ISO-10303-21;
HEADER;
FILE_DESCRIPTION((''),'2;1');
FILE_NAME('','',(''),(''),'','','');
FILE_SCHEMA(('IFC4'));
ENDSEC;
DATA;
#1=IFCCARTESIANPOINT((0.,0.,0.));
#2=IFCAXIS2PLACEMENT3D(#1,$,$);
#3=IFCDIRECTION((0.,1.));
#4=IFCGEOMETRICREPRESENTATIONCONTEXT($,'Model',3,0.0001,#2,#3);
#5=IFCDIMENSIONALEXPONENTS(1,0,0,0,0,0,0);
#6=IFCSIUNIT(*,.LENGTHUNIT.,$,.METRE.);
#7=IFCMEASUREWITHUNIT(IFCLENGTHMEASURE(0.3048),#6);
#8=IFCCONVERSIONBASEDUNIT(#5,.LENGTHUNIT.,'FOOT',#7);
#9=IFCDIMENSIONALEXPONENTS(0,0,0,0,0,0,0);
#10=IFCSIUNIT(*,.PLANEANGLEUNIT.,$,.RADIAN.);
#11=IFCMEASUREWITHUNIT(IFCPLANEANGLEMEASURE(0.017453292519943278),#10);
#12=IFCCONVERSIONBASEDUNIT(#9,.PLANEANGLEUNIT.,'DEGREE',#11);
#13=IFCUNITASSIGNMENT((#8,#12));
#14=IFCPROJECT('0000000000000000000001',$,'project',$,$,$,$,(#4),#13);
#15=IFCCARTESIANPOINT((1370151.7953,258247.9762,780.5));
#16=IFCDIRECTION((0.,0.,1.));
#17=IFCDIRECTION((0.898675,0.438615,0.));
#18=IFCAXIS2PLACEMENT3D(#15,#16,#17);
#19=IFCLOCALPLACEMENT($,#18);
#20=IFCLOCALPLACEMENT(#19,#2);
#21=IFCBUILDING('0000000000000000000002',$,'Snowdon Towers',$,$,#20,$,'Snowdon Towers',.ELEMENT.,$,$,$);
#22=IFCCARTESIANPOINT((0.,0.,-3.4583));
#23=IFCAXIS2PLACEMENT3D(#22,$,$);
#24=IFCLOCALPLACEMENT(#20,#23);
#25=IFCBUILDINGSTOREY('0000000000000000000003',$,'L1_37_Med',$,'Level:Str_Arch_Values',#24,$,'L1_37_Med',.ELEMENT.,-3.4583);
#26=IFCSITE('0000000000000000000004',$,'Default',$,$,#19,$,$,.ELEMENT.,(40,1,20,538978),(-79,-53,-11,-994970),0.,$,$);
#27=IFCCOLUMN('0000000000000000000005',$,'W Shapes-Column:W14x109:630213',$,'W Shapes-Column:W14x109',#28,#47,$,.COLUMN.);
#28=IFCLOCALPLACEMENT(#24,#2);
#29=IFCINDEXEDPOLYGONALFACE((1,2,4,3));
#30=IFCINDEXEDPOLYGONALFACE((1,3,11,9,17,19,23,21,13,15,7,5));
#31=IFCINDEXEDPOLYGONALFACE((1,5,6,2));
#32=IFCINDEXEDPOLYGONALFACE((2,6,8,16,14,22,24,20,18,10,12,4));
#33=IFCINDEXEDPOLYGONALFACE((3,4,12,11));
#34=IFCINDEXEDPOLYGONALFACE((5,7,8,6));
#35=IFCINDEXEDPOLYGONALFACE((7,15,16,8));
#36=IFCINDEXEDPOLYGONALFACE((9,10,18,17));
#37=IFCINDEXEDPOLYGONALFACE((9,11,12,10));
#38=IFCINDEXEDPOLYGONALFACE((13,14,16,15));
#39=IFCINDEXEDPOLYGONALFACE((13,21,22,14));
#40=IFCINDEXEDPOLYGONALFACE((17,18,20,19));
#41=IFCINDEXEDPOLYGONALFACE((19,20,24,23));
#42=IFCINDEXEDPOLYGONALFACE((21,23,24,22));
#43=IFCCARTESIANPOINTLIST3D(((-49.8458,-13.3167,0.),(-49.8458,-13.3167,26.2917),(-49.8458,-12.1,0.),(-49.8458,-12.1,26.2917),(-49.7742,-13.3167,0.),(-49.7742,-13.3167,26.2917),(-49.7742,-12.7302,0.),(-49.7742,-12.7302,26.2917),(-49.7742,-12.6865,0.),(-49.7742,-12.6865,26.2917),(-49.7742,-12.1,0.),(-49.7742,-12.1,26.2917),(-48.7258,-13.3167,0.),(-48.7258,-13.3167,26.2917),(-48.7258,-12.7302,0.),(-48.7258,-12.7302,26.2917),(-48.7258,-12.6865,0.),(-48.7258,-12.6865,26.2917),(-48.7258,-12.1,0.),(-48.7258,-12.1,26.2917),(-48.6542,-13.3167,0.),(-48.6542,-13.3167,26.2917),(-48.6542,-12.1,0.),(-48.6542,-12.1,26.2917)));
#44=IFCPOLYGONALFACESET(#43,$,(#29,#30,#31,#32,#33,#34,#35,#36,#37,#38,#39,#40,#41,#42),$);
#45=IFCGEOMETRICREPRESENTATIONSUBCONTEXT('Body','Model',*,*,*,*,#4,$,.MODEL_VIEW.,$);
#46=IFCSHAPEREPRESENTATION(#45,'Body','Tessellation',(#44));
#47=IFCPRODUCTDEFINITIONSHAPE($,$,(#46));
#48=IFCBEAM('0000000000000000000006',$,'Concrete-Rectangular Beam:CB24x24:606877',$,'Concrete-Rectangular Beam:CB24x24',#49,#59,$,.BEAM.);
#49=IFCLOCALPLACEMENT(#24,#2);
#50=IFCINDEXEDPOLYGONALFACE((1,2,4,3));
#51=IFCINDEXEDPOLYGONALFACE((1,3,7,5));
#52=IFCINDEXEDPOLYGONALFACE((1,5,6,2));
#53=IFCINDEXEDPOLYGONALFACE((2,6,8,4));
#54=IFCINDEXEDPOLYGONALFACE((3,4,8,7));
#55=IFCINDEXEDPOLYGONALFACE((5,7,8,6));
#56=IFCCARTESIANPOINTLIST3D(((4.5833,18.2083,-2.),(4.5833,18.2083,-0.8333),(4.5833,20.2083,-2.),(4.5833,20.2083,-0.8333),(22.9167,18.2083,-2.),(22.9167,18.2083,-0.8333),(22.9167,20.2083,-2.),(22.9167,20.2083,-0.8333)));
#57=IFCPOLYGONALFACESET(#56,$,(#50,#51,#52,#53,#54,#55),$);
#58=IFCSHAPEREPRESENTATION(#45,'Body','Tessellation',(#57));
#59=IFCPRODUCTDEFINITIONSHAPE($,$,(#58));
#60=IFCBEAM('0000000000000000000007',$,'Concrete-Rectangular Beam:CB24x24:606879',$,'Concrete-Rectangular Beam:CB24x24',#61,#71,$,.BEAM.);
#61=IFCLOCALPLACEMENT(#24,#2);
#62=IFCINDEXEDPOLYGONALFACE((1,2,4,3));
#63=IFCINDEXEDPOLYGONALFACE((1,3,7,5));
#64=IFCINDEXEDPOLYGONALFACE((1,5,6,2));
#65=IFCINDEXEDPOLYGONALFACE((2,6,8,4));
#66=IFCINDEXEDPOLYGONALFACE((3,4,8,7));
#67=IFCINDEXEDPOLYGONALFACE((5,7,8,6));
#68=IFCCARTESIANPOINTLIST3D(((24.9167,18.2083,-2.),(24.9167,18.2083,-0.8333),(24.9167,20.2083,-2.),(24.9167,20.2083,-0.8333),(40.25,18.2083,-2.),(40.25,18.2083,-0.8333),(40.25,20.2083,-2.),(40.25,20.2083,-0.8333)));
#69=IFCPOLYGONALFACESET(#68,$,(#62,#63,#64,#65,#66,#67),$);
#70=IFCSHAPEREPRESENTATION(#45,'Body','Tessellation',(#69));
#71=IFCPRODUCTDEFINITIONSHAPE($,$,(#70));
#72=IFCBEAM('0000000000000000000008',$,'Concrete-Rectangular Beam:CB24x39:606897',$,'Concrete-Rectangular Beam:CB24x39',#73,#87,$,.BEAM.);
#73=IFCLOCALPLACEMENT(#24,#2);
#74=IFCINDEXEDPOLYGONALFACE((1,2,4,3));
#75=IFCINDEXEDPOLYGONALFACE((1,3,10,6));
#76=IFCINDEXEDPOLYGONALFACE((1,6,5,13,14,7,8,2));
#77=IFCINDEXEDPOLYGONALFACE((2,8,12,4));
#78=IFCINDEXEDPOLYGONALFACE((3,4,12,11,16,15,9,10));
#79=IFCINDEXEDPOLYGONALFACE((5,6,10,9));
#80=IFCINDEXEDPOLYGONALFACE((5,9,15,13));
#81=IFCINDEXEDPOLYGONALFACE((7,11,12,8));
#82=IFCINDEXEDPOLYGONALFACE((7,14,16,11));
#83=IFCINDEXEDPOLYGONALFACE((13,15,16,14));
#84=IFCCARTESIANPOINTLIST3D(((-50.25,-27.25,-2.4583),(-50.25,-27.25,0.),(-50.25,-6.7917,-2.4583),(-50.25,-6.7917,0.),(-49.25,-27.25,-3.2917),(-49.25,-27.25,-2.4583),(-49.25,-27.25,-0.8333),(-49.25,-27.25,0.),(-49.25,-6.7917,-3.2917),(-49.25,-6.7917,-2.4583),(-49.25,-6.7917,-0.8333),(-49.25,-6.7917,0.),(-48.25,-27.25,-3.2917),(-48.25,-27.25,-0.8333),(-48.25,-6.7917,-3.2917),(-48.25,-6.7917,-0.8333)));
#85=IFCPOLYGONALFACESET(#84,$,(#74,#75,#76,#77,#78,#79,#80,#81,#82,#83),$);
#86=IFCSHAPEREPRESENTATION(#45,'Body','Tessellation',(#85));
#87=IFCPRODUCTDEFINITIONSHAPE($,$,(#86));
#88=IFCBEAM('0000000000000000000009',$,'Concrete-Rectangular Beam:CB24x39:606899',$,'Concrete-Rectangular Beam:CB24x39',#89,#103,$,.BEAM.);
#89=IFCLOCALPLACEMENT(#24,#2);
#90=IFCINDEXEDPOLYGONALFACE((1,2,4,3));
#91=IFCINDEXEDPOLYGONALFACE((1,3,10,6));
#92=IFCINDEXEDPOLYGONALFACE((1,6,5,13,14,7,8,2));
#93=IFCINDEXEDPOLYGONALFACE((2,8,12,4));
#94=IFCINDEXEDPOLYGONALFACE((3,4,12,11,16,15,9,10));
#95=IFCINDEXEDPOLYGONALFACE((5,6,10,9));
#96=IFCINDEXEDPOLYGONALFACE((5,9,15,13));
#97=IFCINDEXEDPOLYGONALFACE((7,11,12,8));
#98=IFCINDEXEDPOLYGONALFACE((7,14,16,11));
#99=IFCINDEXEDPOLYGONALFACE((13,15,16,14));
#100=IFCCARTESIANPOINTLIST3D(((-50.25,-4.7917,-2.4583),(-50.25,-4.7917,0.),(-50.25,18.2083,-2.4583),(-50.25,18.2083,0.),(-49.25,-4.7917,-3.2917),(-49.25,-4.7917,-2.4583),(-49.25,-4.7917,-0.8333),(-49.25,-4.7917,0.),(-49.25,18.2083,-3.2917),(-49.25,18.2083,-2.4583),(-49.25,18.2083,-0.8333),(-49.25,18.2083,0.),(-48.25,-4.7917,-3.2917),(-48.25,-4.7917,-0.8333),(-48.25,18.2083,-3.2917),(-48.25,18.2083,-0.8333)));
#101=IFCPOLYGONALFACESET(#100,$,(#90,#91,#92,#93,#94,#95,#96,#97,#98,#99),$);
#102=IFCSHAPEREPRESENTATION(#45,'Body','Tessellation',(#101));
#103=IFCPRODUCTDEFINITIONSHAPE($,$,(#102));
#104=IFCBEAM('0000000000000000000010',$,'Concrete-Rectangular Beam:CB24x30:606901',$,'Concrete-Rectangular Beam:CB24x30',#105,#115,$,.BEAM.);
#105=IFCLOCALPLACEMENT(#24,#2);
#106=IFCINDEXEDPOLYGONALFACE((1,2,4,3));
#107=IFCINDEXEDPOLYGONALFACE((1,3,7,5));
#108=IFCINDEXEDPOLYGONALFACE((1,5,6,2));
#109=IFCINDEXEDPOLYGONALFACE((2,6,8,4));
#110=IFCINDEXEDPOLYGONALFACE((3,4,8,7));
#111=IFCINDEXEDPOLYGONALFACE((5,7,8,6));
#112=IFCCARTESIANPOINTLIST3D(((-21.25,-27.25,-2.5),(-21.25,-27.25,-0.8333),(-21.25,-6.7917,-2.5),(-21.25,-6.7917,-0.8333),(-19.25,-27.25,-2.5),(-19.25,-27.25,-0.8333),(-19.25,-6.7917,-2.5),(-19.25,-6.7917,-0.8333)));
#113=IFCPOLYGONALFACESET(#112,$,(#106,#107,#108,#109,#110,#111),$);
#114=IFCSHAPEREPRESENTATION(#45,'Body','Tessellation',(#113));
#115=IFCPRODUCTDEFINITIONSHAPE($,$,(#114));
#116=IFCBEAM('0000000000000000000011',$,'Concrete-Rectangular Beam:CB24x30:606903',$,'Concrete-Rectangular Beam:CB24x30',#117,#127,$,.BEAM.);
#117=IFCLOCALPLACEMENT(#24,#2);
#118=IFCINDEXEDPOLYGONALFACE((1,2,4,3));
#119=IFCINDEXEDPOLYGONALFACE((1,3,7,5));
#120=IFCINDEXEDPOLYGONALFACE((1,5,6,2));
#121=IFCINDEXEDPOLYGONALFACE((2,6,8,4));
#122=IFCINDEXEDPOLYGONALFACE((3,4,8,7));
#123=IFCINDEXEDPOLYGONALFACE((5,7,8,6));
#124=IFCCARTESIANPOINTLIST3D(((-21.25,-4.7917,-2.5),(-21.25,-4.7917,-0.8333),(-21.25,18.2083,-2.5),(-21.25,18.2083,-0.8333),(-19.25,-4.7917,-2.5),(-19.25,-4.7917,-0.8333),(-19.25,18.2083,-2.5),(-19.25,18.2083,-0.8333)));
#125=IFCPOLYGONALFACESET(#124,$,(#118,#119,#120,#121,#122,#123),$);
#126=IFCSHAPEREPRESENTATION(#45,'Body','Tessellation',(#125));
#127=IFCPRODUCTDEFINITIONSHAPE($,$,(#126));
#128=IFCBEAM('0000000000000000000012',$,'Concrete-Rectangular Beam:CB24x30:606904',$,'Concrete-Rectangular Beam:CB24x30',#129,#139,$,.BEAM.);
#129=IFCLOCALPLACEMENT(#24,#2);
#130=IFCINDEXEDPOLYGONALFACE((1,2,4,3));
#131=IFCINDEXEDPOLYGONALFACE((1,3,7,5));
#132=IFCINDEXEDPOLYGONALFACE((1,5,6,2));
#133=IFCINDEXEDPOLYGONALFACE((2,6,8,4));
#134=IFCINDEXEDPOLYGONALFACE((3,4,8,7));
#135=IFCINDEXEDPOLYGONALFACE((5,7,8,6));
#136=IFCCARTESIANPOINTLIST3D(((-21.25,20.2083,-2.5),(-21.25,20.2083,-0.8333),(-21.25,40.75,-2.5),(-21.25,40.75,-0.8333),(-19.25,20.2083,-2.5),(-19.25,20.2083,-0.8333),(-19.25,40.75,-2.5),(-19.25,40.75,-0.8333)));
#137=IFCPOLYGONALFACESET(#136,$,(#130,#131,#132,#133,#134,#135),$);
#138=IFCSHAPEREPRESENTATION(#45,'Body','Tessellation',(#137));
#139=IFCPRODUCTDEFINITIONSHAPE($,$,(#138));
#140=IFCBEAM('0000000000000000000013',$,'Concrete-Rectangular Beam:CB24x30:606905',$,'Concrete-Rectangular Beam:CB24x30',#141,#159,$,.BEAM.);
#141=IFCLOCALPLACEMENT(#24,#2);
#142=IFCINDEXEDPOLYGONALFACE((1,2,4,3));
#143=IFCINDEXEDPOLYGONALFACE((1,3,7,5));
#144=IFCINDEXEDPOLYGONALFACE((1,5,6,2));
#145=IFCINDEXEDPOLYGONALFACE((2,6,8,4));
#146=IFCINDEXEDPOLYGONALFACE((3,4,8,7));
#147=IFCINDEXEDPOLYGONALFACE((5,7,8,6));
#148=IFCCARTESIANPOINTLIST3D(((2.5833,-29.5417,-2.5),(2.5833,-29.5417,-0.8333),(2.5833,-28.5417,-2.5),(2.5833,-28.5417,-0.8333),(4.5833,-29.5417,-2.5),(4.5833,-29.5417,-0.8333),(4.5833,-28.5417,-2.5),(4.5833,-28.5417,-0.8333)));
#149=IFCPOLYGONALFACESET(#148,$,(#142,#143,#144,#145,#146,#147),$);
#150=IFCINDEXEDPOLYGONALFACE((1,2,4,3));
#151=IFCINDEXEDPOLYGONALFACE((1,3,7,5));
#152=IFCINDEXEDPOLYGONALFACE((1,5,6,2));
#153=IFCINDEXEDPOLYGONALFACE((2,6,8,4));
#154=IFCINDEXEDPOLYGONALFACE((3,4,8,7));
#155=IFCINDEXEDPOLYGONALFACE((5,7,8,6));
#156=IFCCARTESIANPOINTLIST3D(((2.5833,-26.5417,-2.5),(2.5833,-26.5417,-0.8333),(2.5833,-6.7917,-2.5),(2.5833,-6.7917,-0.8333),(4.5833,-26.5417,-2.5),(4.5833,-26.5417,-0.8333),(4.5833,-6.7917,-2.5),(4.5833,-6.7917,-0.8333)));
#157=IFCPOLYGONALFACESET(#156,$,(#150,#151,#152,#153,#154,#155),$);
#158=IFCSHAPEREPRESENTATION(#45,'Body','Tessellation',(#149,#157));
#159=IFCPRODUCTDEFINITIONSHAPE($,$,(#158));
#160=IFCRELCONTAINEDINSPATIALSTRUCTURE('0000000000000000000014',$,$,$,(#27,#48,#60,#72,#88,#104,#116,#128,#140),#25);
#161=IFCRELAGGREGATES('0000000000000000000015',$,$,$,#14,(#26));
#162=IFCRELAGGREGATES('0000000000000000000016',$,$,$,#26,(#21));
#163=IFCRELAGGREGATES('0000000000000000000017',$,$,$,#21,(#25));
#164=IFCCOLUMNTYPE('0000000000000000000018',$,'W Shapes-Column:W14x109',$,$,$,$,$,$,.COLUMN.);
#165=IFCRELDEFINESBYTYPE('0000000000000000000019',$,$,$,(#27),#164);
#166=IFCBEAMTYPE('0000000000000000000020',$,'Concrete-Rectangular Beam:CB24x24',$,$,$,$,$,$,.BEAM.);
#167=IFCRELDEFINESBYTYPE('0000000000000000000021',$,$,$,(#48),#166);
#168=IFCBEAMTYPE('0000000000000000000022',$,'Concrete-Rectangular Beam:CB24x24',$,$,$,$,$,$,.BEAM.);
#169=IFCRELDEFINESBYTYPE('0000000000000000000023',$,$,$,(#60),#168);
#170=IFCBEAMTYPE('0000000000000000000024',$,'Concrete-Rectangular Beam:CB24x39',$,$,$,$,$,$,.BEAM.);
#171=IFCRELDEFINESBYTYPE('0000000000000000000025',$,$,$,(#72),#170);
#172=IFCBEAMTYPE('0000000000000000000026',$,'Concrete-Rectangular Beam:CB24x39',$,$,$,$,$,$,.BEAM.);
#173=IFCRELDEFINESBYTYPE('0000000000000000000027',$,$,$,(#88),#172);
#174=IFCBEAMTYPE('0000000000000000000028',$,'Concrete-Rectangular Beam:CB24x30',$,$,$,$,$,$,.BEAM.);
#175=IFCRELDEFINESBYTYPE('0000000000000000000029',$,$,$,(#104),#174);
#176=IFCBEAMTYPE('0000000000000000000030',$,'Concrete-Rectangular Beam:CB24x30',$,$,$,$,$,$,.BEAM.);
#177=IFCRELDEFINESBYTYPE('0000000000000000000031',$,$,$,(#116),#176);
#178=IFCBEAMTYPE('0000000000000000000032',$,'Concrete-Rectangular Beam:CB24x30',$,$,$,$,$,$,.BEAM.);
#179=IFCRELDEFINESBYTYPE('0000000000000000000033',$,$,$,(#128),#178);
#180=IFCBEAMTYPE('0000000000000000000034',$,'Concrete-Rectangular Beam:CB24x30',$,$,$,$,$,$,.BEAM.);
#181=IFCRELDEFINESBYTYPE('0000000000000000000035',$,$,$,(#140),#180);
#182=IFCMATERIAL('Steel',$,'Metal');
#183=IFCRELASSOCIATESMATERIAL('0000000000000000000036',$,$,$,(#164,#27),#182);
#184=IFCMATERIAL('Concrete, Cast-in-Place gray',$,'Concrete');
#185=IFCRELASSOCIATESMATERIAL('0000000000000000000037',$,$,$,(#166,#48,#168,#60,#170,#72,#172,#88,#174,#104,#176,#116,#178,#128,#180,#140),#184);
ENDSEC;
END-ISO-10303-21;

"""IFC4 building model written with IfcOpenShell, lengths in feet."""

from ifc_helpers import new_model, entity, si_unit, converted_unit, direction, frame, origin, place, context, subcontext, project, spatial, indexed_curve, outline, extrude, source, transform, mapped, material, type_object, type_shapes, element, save


model = new_model("IFC4")

# Units and contexts
model_context = context("Model", 3, precision=0.0001, world=origin(), true_north=direction((0.0, 1.0)))
body_context = subcontext(model_context, "Body", "Model", "MODEL_VIEW")
ifc_project = project(units=[converted_unit("LENGTHUNIT", "FOOT", entity("IfcLengthMeasure", 0.3048), si_unit("LENGTHUNIT", "METRE"), dimensions=[1, 0, 0, 0, 0, 0, 0]), converted_unit("PLANEANGLEUNIT", "DEGREE", entity("IfcPlaneAngleMeasure", 0.017453292519943278), si_unit("PLANEANGLEUNIT", "RADIAN"), dimensions=[0, 0, 0, 0, 0, 0, 0])], contexts=[model_context])

# Site, building, storey
site_placement = place(None, frame((1370151.7953, 258247.9762, 780.5), z_axis=(0.0, 0.0, 1.0), x_axis=(0.898675, 0.438615, 0.0)))
site = spatial("IfcSite", under=ifc_project, at=site_placement, Name="Default", CompositionType="ELEMENT", RefLatitude=(40, 1, 20, 538978), RefLongitude=(-79, -53, -11, -994970), RefElevation=0.0)
building_placement = place(site_placement, origin())
building = spatial("IfcBuilding", under=site, at=building_placement, Name="Snowdon Towers", LongName="Snowdon Towers", CompositionType="ELEMENT")
storey_placement = place(building_placement, frame((0.0, 0.0, -3.4583)))
storey = spatial("IfcBuildingStorey", under=building, at=storey_placement, Name="L1_37_Med", ObjectType="Level:Str_Arch_Values", LongName="L1_37_Med", CompositionType="ELEMENT", Elevation=-3.4583)

# Column
ifc_material_1 = material(Name="Steel", Category="Metal")
column_type_1 = type_object("IfcColumnType", Name="W Shapes-Column:W14x109", PredefinedType="COLUMN", material=ifc_material_1)
shared_shape_1 = source(origin(), body_context, "Body", "SweptSolid", [
    extrude(outline(indexed_curve([(-0.6083, -0.5958), (0.6083, -0.5958), (0.6083, -0.5242), (0.0219, -0.5242), (0.0219, 0.5242), (0.6083, 0.5242), (0.6083, 0.5958), (-0.6083, 0.5958), (-0.6083, 0.5242), (-0.0219, 0.5242), (-0.0219, -0.5242), (-0.6083, -0.5242), (-0.6083, -0.5958)], self_intersect=False)), frame((0.0, 0.0, -3.4583), z_axis=(0.0, 0.0, 1.0), x_axis=(-1.0, 0.0, 0.0)), (0.0, 0.0, 1.0), 26.2917),
])
type_shapes(column_type_1, [shared_shape_1])
column_1_placement = place(storey_placement, frame((-49.25, -12.7083, 3.4583), z_axis=(0.0, 0.0, 1.0), x_axis=(0.0, 1.0, 0.0)))
element("IfcColumn", 1, at=column_1_placement, inside=storey, type_object=column_type_1, material=ifc_material_1, Name="W Shapes-Column:W14x109:630213", ObjectType="W Shapes-Column:W14x109", PredefinedType="COLUMN", context=body_context, shape_type="MappedRepresentation", body=[
    mapped(shared_shape_1, transform((0.0, 0.0, 0.0), scale=1.0)),
])

# Beams
ifc_material_2 = material(Name="Concrete, Cast-in-Place gray", Category="Concrete")
beam_type_1 = type_object("IfcBeamType", Name="Concrete-Rectangular Beam:CB24x24", PredefinedType="BEAM", material=ifc_material_2)
shared_shape_2 = source(origin(), body_context, "Body", "SweptSolid", [
    extrude(outline(indexed_curve([(-0.5833, -1.0), (0.5833, -1.0), (0.5833, 1.0), (-0.5833, 1.0), (-0.5833, -1.0)], self_intersect=False)), frame((4.5833, 19.2083, -4.875), z_axis=(1.0, 0.0, 0.0), x_axis=(0.0, 0.0, -1.0)), (0.0, 0.0, 1.0), 18.3333),
])
type_shapes(beam_type_1, [shared_shape_2])
beam_1_placement = place(storey_placement, frame((0.0, 0.0, 3.4583)))
element("IfcBeam", 2, at=beam_1_placement, inside=storey, type_object=beam_type_1, material=ifc_material_2, Name="Concrete-Rectangular Beam:CB24x24:606877", ObjectType="Concrete-Rectangular Beam:CB24x24", PredefinedType="BEAM", context=body_context, shape_type="MappedRepresentation", body=[
    mapped(shared_shape_2, transform((0.0, 0.0, 0.0), scale=1.0)),
])
beam_type_2 = type_object("IfcBeamType", Name="Concrete-Rectangular Beam:CB24x24", PredefinedType="BEAM", material=ifc_material_2)
shared_shape_3 = source(origin(), body_context, "Body", "SweptSolid", [
    extrude(outline(indexed_curve([(-0.5833, -1.0), (0.5833, -1.0), (0.5833, 1.0), (-0.5833, 1.0), (-0.5833, -1.0)], self_intersect=False)), frame((24.9167, 19.2083, -4.875), z_axis=(1.0, 0.0, 0.0), x_axis=(0.0, 0.0, -1.0)), (0.0, 0.0, 1.0), 15.3333),
])
type_shapes(beam_type_2, [shared_shape_3])
beam_2_placement = place(storey_placement, frame((0.0, 0.0, 3.4583)))
element("IfcBeam", 3, at=beam_2_placement, inside=storey, type_object=beam_type_2, material=ifc_material_2, Name="Concrete-Rectangular Beam:CB24x24:606879", ObjectType="Concrete-Rectangular Beam:CB24x24", PredefinedType="BEAM", context=body_context, shape_type="MappedRepresentation", body=[
    mapped(shared_shape_3, transform((0.0, 0.0, 0.0), scale=1.0)),
])
beam_type_3 = type_object("IfcBeamType", Name="Concrete-Rectangular Beam:CB24x39", PredefinedType="BEAM", material=ifc_material_2)
shared_shape_4 = source(origin(), body_context, "Body", "SweptSolid", [
    extrude(outline(indexed_curve([(-1.0, -1.6458), (0.0, -1.6458), (0.0, -0.8125), (1.0, -0.8125), (1.0, 1.6458), (0.0, 1.6458), (0.0, 0.8125), (-1.0, 0.8125), (-1.0, -1.6458)], self_intersect=False)), frame((-49.25, -27.25, -5.1042), z_axis=(0.0, 1.0, 0.0), x_axis=(-1.0, 0.0, 0.0)), (0.0, 0.0, 1.0), 20.4583),
])
type_shapes(beam_type_3, [shared_shape_4])
beam_3_placement = place(storey_placement, frame((0.0, 0.0, 3.4583)))
element("IfcBeam", 4, at=beam_3_placement, inside=storey, type_object=beam_type_3, material=ifc_material_2, Name="Concrete-Rectangular Beam:CB24x39:606897", ObjectType="Concrete-Rectangular Beam:CB24x39", PredefinedType="BEAM", context=body_context, shape_type="MappedRepresentation", body=[
    mapped(shared_shape_4, transform((0.0, 0.0, 0.0), scale=1.0)),
])
beam_type_4 = type_object("IfcBeamType", Name="Concrete-Rectangular Beam:CB24x39", PredefinedType="BEAM", material=ifc_material_2)
shared_shape_5 = source(origin(), body_context, "Body", "SweptSolid", [
    extrude(outline(indexed_curve([(-1.0, -1.6458), (0.0, -1.6458), (0.0, -0.8125), (1.0, -0.8125), (1.0, 1.6458), (0.0, 1.6458), (0.0, 0.8125), (-1.0, 0.8125), (-1.0, -1.6458)], self_intersect=False)), frame((-49.25, -4.7917, -5.1042), z_axis=(0.0, 1.0, 0.0), x_axis=(-1.0, 0.0, 0.0)), (0.0, 0.0, 1.0), 23.0),
])
type_shapes(beam_type_4, [shared_shape_5])
beam_4_placement = place(storey_placement, frame((0.0, 0.0, 3.4583)))
element("IfcBeam", 5, at=beam_4_placement, inside=storey, type_object=beam_type_4, material=ifc_material_2, Name="Concrete-Rectangular Beam:CB24x39:606899", ObjectType="Concrete-Rectangular Beam:CB24x39", PredefinedType="BEAM", context=body_context, shape_type="MappedRepresentation", body=[
    mapped(shared_shape_5, transform((0.0, 0.0, 0.0), scale=1.0)),
])
beam_type_5 = type_object("IfcBeamType", Name="Concrete-Rectangular Beam:CB24x30", PredefinedType="BEAM", material=ifc_material_2)
shared_shape_6 = source(origin(), body_context, "Body", "SweptSolid", [
    extrude(outline(indexed_curve([(-1.0, -0.8333), (1.0, -0.8333), (1.0, 0.8333), (-1.0, 0.8333), (-1.0, -0.8333)], self_intersect=False)), frame((-20.25, -27.25, -5.125), z_axis=(0.0, 1.0, 0.0), x_axis=(-1.0, 0.0, 0.0)), (0.0, 0.0, 1.0), 20.4583),
])
type_shapes(beam_type_5, [shared_shape_6])
beam_5_placement = place(storey_placement, frame((0.0, 0.0, 3.4583)))
element("IfcBeam", 6, at=beam_5_placement, inside=storey, type_object=beam_type_5, material=ifc_material_2, Name="Concrete-Rectangular Beam:CB24x30:606901", ObjectType="Concrete-Rectangular Beam:CB24x30", PredefinedType="BEAM", context=body_context, shape_type="MappedRepresentation", body=[
    mapped(shared_shape_6, transform((0.0, 0.0, 0.0), scale=1.0)),
])
beam_type_6 = type_object("IfcBeamType", Name="Concrete-Rectangular Beam:CB24x30", PredefinedType="BEAM", material=ifc_material_2)
shared_shape_7 = source(origin(), body_context, "Body", "SweptSolid", [
    extrude(outline(indexed_curve([(-1.0, -0.8333), (1.0, -0.8333), (1.0, 0.8333), (-1.0, 0.8333), (-1.0, -0.8333)], self_intersect=False)), frame((-20.25, -4.7917, -5.125), z_axis=(0.0, 1.0, 0.0), x_axis=(-1.0, 0.0, 0.0)), (0.0, 0.0, 1.0), 23.0),
])
type_shapes(beam_type_6, [shared_shape_7])
beam_6_placement = place(storey_placement, frame((0.0, 0.0, 3.4583)))
element("IfcBeam", 7, at=beam_6_placement, inside=storey, type_object=beam_type_6, material=ifc_material_2, Name="Concrete-Rectangular Beam:CB24x30:606903", ObjectType="Concrete-Rectangular Beam:CB24x30", PredefinedType="BEAM", context=body_context, shape_type="MappedRepresentation", body=[
    mapped(shared_shape_7, transform((0.0, 0.0, 0.0), scale=1.0)),
])
beam_type_7 = type_object("IfcBeamType", Name="Concrete-Rectangular Beam:CB24x30", PredefinedType="BEAM", material=ifc_material_2)
shared_shape_8 = source(origin(), body_context, "Body", "SweptSolid", [
    extrude(outline(indexed_curve([(-1.0, -0.8333), (1.0, -0.8333), (1.0, 0.8333), (-1.0, 0.8333), (-1.0, -0.8333)], self_intersect=False)), frame((-20.25, 20.2083, -5.125), z_axis=(0.0, 1.0, 0.0), x_axis=(-1.0, 0.0, 0.0)), (0.0, 0.0, 1.0), 20.5417),
])
type_shapes(beam_type_7, [shared_shape_8])
beam_7_placement = place(storey_placement, frame((0.0, 0.0, 3.4583)))
element("IfcBeam", 8, at=beam_7_placement, inside=storey, type_object=beam_type_7, material=ifc_material_2, Name="Concrete-Rectangular Beam:CB24x30:606904", ObjectType="Concrete-Rectangular Beam:CB24x30", PredefinedType="BEAM", context=body_context, shape_type="MappedRepresentation", body=[
    mapped(shared_shape_8, transform((0.0, 0.0, 0.0), scale=1.0)),
])
beam_type_8 = type_object("IfcBeamType", Name="Concrete-Rectangular Beam:CB24x30", PredefinedType="BEAM", material=ifc_material_2)
shared_shape_9 = source(origin(), body_context, "Body", "SweptSolid", [
    extrude(outline(indexed_curve([(-1.0, -0.8333), (1.0, -0.8333), (1.0, 0.8333), (-1.0, 0.8333), (-1.0, -0.8333)], self_intersect=False)), frame((3.5833, -29.5417, -5.125), z_axis=(0.0, 1.0, 0.0), x_axis=(-1.0, 0.0, 0.0)), (0.0, 0.0, 1.0), 1.0),
    extrude(outline(indexed_curve([(-1.0, -0.8333), (1.0, -0.8333), (1.0, 0.8333), (-1.0, 0.8333), (-1.0, -0.8333)], self_intersect=False)), frame((3.5833, -26.5417, -5.125), z_axis=(0.0, 1.0, 0.0), x_axis=(-1.0, 0.0, 0.0)), (0.0, 0.0, 1.0), 19.75),
])
type_shapes(beam_type_8, [shared_shape_9])
beam_8_placement = place(storey_placement, frame((0.0, 0.0, 3.4583)))
element("IfcBeam", 9, at=beam_8_placement, inside=storey, type_object=beam_type_8, material=ifc_material_2, Name="Concrete-Rectangular Beam:CB24x30:606905", ObjectType="Concrete-Rectangular Beam:CB24x30", PredefinedType="BEAM", context=body_context, shape_type="MappedRepresentation", body=[
    mapped(shared_shape_9, transform((0.0, 0.0, 0.0), scale=1.0)),
])

save(model, "model.ifc")
